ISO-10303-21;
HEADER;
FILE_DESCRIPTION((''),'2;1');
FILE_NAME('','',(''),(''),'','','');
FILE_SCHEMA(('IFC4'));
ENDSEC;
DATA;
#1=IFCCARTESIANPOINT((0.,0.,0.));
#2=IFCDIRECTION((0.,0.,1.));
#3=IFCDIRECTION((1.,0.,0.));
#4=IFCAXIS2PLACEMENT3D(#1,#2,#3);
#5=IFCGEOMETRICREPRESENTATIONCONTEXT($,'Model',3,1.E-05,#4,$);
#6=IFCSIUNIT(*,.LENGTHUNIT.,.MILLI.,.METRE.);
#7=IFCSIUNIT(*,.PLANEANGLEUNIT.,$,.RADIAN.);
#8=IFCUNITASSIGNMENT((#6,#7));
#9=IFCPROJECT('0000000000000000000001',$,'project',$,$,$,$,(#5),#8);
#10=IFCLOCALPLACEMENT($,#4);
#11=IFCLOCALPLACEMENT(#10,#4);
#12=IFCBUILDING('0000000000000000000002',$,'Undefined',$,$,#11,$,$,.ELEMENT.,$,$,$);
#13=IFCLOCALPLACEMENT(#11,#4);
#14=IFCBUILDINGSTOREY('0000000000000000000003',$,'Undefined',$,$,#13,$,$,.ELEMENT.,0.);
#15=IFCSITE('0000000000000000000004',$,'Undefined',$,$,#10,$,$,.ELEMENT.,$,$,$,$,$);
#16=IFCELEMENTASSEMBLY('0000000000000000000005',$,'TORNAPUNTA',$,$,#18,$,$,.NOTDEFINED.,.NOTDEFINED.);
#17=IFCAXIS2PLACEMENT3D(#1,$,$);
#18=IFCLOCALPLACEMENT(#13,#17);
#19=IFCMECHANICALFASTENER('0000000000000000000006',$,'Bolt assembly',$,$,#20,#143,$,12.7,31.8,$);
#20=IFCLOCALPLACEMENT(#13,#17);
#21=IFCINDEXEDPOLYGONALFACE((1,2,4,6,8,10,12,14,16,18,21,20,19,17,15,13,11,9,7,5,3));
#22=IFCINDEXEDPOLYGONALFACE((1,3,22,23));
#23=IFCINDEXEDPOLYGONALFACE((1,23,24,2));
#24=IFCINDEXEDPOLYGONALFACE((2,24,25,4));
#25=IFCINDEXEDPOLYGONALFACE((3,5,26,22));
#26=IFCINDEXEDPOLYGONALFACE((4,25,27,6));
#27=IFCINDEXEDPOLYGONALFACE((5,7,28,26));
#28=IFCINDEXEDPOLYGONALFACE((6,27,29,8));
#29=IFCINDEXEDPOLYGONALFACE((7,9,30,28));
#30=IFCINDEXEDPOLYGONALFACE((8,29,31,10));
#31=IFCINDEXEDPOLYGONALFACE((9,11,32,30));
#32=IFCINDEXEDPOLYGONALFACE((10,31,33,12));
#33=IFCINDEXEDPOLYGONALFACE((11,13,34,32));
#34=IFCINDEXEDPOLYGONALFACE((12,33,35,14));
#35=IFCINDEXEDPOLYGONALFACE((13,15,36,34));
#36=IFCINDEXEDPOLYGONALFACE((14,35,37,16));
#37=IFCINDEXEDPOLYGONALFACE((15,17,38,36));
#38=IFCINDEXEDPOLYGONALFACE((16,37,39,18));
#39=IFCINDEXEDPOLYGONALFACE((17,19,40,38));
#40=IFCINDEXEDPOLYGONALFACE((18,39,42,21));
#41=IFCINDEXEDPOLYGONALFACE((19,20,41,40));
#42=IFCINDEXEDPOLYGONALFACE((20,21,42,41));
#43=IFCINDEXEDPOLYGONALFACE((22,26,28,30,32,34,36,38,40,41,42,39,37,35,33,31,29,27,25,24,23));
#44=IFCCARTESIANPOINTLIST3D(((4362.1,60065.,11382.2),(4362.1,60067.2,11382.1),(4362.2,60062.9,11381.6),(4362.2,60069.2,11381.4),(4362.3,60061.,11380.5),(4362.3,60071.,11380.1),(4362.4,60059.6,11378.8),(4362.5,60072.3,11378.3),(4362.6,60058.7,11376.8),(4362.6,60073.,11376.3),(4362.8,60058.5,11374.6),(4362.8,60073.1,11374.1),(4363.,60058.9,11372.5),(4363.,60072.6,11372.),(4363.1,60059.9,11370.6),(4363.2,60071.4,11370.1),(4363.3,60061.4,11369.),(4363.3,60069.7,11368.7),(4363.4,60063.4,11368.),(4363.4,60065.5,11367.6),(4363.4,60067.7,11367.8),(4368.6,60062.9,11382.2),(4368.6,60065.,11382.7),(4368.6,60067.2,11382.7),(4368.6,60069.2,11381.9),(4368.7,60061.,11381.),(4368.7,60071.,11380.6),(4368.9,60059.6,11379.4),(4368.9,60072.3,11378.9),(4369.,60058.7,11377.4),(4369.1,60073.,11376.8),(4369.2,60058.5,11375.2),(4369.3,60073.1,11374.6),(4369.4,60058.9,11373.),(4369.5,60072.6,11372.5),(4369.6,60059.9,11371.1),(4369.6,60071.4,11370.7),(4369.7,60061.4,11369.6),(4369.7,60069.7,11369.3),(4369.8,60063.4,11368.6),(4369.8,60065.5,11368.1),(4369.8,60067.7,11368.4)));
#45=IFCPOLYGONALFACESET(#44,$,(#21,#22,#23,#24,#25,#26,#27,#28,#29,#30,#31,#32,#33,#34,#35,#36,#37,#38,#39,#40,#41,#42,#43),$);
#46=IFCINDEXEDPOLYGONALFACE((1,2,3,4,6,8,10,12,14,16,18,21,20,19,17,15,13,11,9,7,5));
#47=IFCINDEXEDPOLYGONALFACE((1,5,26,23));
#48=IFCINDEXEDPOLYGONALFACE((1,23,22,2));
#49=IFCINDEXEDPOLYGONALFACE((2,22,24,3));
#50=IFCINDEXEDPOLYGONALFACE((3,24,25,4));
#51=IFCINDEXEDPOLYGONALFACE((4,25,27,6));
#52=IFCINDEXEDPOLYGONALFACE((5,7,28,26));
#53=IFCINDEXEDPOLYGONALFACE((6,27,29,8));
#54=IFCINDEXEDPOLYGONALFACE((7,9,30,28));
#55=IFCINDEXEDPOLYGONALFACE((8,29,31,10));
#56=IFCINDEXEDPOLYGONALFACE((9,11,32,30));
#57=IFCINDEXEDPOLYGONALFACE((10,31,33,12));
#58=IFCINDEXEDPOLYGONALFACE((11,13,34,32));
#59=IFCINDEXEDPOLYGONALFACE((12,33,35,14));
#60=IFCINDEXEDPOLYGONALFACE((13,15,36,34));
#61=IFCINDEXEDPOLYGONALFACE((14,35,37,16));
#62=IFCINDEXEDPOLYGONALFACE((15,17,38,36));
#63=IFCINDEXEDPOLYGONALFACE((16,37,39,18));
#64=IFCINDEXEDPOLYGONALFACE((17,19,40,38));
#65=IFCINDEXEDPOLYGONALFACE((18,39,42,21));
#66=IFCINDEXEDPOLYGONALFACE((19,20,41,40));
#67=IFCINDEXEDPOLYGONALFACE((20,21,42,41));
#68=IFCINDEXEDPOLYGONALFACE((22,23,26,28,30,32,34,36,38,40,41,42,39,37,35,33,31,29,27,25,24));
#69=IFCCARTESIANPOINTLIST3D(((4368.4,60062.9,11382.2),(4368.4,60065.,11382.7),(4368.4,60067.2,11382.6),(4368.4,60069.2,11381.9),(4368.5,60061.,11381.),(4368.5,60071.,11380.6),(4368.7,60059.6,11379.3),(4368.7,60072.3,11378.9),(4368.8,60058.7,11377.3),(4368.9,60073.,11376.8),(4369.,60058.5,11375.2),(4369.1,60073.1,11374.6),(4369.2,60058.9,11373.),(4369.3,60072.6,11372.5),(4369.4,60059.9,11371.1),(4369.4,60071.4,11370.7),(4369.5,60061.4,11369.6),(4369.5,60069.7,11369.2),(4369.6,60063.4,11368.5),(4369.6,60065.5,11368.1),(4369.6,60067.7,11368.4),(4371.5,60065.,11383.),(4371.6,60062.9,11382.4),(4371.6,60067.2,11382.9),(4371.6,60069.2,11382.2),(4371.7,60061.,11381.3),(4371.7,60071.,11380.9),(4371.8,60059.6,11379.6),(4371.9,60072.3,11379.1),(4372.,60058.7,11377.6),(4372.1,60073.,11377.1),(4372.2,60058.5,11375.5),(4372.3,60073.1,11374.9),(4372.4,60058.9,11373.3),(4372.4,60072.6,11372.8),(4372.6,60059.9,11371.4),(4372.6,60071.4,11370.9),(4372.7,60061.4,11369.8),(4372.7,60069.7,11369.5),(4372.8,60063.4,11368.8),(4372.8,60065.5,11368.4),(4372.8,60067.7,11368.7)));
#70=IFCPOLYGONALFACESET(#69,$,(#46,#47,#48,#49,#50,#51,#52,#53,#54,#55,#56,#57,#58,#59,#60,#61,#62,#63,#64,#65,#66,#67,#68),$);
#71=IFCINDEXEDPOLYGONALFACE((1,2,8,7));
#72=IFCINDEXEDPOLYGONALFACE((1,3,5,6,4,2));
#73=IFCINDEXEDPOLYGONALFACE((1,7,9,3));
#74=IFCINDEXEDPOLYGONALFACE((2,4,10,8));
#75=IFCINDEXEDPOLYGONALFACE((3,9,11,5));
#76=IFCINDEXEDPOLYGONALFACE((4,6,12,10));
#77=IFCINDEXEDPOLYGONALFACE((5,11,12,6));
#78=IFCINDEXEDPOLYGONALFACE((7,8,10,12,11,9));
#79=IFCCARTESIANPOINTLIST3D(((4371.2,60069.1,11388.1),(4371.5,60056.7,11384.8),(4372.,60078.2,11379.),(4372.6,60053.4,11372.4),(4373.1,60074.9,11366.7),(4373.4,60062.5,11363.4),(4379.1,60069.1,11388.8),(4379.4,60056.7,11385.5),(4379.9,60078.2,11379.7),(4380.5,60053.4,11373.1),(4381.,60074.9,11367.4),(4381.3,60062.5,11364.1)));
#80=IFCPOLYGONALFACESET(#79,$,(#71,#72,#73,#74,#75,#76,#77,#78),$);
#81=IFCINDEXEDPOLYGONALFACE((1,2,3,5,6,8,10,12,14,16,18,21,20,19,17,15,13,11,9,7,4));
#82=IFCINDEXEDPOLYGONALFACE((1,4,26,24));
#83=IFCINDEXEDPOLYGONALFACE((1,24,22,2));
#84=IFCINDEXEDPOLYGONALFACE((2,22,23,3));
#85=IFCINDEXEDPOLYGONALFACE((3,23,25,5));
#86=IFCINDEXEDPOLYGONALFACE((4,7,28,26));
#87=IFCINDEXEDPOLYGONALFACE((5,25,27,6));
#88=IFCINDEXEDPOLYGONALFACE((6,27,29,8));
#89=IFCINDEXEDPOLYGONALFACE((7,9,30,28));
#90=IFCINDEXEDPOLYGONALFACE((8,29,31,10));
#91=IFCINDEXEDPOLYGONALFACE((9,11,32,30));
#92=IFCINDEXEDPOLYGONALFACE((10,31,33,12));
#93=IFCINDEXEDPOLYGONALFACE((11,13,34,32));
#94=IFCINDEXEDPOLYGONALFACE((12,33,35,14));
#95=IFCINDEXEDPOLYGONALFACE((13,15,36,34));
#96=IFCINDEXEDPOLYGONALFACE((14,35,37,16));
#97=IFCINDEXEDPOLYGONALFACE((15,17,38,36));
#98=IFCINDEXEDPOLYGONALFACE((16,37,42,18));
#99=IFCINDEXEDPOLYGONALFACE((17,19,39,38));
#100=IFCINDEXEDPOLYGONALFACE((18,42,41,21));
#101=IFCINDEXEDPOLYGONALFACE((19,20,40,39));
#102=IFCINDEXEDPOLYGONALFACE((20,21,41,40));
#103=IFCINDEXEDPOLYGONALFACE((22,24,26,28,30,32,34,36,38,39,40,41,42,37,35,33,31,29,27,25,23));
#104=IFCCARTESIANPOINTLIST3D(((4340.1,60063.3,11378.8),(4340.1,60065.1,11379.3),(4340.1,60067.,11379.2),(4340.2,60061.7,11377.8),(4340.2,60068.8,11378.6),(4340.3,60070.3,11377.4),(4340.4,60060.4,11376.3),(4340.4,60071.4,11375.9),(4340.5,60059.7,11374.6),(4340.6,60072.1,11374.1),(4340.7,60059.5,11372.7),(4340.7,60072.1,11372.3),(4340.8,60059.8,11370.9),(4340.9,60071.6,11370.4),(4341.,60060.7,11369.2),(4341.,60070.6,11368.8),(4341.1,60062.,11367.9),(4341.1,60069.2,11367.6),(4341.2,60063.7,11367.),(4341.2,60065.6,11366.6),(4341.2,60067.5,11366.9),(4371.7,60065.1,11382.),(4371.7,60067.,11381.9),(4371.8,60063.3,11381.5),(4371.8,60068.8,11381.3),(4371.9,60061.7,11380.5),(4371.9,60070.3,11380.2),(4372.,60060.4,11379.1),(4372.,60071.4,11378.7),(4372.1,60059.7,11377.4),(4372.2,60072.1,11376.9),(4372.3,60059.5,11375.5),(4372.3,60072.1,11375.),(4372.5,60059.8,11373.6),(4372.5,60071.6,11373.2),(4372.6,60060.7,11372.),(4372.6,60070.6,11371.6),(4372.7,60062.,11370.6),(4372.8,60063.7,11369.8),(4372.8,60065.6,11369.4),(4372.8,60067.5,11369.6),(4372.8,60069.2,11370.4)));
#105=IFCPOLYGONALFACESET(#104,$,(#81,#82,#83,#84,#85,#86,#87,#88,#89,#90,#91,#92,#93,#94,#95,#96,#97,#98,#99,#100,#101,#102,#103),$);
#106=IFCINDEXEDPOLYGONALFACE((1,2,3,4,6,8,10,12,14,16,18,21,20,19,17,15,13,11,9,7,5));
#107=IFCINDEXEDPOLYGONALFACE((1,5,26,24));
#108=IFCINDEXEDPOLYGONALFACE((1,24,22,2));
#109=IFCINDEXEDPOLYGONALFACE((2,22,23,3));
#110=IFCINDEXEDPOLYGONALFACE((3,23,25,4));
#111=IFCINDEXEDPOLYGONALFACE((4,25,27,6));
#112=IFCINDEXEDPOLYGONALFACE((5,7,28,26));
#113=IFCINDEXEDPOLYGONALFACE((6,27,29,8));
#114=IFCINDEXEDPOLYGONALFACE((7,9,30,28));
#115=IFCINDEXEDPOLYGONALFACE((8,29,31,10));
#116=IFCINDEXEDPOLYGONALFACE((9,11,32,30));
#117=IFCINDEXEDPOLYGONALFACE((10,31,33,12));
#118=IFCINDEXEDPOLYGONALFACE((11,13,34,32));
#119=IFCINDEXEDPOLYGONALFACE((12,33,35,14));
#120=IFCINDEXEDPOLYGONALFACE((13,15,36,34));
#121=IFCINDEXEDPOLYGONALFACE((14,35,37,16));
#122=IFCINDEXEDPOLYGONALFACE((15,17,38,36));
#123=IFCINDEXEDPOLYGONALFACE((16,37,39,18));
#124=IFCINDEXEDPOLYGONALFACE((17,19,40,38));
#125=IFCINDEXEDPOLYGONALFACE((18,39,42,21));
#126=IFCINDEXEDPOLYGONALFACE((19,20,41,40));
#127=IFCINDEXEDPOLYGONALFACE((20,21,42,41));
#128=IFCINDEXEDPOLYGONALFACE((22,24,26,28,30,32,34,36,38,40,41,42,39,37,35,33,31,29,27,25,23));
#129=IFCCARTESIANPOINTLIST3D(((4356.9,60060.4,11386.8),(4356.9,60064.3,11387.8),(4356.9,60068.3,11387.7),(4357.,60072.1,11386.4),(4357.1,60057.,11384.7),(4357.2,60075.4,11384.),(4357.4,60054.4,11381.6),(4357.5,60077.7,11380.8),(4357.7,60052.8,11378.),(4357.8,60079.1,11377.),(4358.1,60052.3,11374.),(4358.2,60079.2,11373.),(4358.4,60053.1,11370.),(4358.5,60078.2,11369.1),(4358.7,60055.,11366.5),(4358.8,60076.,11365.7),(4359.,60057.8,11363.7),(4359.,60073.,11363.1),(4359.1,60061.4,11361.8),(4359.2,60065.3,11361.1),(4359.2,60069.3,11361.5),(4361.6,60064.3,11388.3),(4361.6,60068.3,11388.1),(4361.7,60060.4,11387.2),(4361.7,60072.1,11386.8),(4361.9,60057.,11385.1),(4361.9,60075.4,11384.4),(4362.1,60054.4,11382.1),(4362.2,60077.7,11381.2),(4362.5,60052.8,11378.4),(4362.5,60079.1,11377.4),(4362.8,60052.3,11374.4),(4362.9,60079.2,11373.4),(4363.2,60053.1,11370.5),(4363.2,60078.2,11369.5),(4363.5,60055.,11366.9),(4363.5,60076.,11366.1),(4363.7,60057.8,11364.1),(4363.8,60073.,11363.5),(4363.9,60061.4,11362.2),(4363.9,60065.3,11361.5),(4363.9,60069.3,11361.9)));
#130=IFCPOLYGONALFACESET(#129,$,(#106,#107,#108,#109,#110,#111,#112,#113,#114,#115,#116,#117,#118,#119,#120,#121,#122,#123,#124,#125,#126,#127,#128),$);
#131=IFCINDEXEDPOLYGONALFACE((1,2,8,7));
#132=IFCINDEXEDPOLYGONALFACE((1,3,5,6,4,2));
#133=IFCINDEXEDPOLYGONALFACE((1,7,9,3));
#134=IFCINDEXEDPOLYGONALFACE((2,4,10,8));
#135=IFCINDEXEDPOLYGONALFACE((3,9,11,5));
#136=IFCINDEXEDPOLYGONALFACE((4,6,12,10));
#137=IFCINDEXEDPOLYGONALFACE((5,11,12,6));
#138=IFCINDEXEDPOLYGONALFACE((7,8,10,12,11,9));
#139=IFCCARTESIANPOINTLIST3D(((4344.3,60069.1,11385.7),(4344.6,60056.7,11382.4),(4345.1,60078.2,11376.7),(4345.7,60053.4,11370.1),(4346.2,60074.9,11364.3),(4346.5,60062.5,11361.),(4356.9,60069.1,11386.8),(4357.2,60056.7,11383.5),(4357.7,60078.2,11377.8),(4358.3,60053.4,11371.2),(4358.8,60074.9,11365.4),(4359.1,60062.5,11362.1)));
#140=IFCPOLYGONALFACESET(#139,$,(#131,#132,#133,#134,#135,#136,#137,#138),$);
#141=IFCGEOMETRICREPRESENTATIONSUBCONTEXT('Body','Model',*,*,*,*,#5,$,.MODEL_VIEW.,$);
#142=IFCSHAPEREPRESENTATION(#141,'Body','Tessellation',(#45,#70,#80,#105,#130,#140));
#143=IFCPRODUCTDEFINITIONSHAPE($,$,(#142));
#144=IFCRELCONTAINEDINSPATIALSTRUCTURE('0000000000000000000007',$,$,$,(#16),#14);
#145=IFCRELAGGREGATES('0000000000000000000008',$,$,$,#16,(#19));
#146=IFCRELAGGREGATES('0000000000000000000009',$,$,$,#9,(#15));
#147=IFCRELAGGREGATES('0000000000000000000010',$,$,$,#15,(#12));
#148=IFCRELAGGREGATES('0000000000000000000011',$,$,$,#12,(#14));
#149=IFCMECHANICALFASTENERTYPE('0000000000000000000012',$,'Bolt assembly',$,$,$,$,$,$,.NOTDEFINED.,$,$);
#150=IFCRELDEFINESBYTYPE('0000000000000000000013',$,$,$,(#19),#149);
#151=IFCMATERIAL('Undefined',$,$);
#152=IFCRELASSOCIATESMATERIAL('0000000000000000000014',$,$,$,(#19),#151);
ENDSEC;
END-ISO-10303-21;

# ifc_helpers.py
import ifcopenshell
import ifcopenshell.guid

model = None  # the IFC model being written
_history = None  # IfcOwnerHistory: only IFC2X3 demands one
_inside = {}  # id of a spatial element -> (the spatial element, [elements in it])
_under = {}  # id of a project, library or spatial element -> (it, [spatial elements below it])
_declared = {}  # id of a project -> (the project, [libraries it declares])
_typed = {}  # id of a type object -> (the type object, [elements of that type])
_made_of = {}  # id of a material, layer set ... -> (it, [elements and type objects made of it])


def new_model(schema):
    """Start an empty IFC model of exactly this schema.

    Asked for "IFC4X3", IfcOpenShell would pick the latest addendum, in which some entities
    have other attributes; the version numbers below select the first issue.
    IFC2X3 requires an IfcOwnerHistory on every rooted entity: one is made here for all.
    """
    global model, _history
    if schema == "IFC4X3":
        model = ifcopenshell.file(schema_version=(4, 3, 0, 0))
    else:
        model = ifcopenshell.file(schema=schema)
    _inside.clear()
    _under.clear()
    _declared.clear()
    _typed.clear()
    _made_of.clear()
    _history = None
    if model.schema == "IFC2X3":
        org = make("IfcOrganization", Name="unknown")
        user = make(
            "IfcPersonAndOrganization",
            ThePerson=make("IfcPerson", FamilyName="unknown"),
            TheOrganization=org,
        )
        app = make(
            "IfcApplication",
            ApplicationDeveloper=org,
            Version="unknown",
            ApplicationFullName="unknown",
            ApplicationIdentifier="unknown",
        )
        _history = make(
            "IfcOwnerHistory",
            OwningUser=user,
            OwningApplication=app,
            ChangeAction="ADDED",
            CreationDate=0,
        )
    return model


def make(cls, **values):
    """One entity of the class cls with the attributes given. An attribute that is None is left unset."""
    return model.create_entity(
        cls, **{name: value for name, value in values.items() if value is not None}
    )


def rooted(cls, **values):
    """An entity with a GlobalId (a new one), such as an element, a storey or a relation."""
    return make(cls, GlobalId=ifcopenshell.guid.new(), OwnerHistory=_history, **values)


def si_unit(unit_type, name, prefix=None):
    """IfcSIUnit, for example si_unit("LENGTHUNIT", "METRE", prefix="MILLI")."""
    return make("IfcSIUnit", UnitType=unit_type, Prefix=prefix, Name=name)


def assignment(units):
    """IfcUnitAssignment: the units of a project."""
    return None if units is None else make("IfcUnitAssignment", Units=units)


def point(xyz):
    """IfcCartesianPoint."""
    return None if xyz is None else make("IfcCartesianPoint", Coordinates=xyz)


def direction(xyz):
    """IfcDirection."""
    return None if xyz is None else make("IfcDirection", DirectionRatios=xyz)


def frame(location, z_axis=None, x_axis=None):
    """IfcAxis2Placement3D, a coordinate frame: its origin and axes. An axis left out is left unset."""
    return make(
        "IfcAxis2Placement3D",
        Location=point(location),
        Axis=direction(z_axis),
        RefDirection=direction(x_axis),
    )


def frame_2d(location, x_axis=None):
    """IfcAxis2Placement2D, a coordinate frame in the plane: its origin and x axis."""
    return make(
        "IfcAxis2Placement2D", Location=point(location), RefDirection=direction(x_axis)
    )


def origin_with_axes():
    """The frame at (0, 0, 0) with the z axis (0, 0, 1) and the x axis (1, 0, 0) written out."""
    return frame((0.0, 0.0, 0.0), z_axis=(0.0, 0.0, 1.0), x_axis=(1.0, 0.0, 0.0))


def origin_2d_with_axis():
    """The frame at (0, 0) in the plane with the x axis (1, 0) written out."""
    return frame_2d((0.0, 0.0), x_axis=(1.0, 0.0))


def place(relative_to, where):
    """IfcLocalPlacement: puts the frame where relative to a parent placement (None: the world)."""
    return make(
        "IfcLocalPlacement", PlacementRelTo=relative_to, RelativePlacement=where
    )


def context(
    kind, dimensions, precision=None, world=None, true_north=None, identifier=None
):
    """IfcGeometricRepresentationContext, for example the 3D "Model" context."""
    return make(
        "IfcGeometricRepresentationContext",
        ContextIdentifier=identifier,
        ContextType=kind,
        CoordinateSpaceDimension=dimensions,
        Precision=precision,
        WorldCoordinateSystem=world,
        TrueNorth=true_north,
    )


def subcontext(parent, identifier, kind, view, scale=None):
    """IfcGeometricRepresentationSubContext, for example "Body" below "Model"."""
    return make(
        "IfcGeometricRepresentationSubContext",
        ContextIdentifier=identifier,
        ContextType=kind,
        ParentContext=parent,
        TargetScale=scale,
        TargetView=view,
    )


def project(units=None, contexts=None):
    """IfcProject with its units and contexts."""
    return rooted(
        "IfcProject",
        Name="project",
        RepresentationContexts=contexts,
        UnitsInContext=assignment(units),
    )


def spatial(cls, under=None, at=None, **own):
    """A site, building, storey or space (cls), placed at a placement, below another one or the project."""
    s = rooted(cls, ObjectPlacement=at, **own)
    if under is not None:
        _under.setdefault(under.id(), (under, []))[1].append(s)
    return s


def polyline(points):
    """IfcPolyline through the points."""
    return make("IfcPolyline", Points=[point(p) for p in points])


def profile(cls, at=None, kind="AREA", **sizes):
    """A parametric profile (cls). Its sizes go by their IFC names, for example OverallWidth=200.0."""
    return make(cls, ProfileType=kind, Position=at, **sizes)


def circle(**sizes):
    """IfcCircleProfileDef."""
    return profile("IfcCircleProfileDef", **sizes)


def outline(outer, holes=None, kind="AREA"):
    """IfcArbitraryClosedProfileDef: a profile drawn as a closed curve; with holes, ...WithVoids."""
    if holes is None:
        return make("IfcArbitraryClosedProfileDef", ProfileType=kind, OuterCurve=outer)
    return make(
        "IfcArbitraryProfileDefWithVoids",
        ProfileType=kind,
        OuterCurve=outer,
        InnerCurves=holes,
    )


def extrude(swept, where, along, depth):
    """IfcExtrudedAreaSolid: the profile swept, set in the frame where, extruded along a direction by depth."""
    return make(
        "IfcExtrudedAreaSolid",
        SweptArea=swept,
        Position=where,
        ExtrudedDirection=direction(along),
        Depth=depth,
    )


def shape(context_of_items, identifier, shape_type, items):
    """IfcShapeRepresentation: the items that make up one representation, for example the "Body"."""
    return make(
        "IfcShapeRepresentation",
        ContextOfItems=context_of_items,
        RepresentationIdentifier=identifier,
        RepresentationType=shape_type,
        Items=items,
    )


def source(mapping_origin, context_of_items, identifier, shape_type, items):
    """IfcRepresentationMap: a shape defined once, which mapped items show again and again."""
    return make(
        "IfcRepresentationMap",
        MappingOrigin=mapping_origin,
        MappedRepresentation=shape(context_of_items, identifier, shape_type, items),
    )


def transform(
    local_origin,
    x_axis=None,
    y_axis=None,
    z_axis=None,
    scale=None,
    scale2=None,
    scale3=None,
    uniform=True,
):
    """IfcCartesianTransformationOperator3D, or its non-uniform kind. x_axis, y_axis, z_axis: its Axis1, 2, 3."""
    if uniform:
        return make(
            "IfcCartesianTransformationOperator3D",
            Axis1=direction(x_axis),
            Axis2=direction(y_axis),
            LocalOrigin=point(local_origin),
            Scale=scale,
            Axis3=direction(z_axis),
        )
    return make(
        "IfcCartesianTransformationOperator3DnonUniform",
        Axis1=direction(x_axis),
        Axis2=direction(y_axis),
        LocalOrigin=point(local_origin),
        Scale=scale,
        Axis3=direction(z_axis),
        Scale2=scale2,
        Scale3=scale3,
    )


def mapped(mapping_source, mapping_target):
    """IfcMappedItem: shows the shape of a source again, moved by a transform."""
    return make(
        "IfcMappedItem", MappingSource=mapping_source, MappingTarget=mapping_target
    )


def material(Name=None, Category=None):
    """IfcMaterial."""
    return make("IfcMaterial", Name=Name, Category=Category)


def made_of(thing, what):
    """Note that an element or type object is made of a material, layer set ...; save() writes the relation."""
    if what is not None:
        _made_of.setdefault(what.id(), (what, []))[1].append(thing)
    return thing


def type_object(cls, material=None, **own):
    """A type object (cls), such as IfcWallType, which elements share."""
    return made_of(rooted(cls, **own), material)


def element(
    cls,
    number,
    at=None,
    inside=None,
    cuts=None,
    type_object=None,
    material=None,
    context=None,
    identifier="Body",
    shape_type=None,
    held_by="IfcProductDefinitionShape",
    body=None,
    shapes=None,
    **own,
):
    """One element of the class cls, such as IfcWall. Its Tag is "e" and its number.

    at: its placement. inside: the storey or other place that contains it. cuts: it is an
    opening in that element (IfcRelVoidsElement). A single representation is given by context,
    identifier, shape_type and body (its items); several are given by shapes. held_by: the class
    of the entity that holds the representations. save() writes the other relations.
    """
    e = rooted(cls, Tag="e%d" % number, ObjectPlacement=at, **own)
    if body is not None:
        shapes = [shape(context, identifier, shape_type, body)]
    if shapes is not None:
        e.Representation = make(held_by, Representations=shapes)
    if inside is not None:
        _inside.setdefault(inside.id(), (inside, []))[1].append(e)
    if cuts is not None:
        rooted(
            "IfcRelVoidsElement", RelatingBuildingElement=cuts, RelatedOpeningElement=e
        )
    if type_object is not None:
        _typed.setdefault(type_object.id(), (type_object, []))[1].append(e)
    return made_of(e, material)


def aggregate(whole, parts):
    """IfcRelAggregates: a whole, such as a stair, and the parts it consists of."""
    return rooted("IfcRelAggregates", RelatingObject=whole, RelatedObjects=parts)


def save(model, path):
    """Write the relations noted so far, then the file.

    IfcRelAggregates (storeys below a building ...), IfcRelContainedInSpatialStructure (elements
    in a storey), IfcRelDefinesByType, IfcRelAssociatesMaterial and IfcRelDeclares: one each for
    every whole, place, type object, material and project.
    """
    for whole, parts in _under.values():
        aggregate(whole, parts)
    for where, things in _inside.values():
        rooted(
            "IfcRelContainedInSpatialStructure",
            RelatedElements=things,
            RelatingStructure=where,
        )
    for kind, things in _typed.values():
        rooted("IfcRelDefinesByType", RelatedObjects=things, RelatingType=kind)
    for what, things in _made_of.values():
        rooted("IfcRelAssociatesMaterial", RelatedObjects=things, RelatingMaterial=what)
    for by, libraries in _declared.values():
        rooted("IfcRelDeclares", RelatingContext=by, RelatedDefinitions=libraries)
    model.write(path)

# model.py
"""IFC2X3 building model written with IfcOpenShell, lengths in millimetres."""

from ifc_helpers import new_model, si_unit, frame, origin_with_axes, origin_2d_with_axis, place, context, subcontext, project, spatial, polyline, circle, outline, extrude, source, transform, mapped, material, type_object, element, aggregate, save


model = new_model("IFC2X3")

# Units and contexts
model_context = context("Model", 3, precision=1e-05, world=origin_with_axes())
body_context = subcontext(model_context, "Body", "Model", "MODEL_VIEW")
ifc_project = project(units=[si_unit("LENGTHUNIT", "METRE", prefix="MILLI"), si_unit("PLANEANGLEUNIT", "RADIAN")], contexts=[model_context])

# Site, building, storey
site_placement = place(None, origin_with_axes())
site = spatial("IfcSite", under=ifc_project, at=site_placement, Name="Undefined", CompositionType="ELEMENT")
building_placement = place(site_placement, origin_with_axes())
building = spatial("IfcBuilding", under=site, at=building_placement, Name="Undefined", CompositionType="ELEMENT")
storey_placement = place(building_placement, origin_with_axes())
storey = spatial("IfcBuildingStorey", under=building, at=storey_placement, Name="Undefined", CompositionType="ELEMENT", Elevation=0.0)

# Element assembly
assembly_1_placement = place(storey_placement, origin_with_axes())
assembly_1 = element("IfcElementAssembly", 1, at=assembly_1_placement, inside=storey, Name="TORNAPUNTA", AssemblyPlace="NOTDEFINED", PredefinedType="NOTDEFINED")

# Mechanical fastener
ifc_material_1 = material(Name="Undefined")
mechanical_fastener_type = type_object("IfcMechanicalFastenerType", Name="Bolt assembly")
shared_shape_1 = source(origin_with_axes(), body_context, "Body", "SweptSolid", [
    extrude(circle(Radius=7.3, at=origin_2d_with_axis()), frame((0.0, -0.1, 0.0), z_axis=(0.0, 1.0, 0.0), x_axis=(1.0, 0.0, 0.0)), (0.0, 0.0, 1.0), 6.5),
    extrude(circle(Radius=7.3, at=origin_2d_with_axis()), frame((0.0, -3.1, 0.0), z_axis=(0.0, 1.0, 0.0), x_axis=(1.0, 0.0, 0.0)), (0.0, 0.0, 1.0), 3.2),
    extrude(outline(polyline([(11.1, -6.4), (11.1, 6.4), (0.0, 12.8), (-11.1, 6.4), (-11.1, -6.4), (0.0, -12.8), (11.1, -6.4)])), frame((0.0, -11.1, 0.0), z_axis=(0.0, 1.0, 0.0), x_axis=(1.0, 0.0, 0.0)), (0.0, 0.0, 1.0), 7.9),
    extrude(circle(Radius=6.3, at=origin_2d_with_axis()), frame((0.0, -3.2, 0.0), z_axis=(0.0, 1.0, 0.0), x_axis=(1.0, 0.0, 0.0)), (0.0, 0.0, 1.0), 31.8),
    extrude(circle(Radius=13.5, at=origin_2d_with_axis()), frame((0.0, 6.3, 0.0), z_axis=(0.0, 1.0, 0.0), x_axis=(1.0, 0.0, 0.0)), (0.0, 0.0, 1.0), 4.8),
    extrude(outline(polyline([(11.1, -6.4), (11.1, 6.4), (0.0, 12.8), (-11.1, 6.4), (-11.1, -6.4), (0.0, -12.8), (11.1, -6.4)])), frame((0.0, 11.1, 0.0), z_axis=(0.0, 1.0, 0.0), x_axis=(1.0, 0.0, 0.0)), (0.0, 0.0, 1.0), 12.7),
])
mechanical_fastener_1_placement = place(assembly_1_placement, frame((4369.1, 60065.8, 11375.5), z_axis=(-0.061628, -0.707107, 0.704416), x_axis=(-0.061628, 0.707107, 0.704416)))
mechanical_fastener_1 = element("IfcMechanicalFastener", 2, at=mechanical_fastener_1_placement, type_object=mechanical_fastener_type, material=ifc_material_1, Name="Bolt assembly", NominalDiameter=12.7, NominalLength=31.8, context=body_context, shape_type="MappedRepresentation", body=[
    mapped(shared_shape_1, transform((0.0, 0.0, 0.0))),
])
aggregate(assembly_1, [mechanical_fastener_1])

save(model, "model.ifc")
